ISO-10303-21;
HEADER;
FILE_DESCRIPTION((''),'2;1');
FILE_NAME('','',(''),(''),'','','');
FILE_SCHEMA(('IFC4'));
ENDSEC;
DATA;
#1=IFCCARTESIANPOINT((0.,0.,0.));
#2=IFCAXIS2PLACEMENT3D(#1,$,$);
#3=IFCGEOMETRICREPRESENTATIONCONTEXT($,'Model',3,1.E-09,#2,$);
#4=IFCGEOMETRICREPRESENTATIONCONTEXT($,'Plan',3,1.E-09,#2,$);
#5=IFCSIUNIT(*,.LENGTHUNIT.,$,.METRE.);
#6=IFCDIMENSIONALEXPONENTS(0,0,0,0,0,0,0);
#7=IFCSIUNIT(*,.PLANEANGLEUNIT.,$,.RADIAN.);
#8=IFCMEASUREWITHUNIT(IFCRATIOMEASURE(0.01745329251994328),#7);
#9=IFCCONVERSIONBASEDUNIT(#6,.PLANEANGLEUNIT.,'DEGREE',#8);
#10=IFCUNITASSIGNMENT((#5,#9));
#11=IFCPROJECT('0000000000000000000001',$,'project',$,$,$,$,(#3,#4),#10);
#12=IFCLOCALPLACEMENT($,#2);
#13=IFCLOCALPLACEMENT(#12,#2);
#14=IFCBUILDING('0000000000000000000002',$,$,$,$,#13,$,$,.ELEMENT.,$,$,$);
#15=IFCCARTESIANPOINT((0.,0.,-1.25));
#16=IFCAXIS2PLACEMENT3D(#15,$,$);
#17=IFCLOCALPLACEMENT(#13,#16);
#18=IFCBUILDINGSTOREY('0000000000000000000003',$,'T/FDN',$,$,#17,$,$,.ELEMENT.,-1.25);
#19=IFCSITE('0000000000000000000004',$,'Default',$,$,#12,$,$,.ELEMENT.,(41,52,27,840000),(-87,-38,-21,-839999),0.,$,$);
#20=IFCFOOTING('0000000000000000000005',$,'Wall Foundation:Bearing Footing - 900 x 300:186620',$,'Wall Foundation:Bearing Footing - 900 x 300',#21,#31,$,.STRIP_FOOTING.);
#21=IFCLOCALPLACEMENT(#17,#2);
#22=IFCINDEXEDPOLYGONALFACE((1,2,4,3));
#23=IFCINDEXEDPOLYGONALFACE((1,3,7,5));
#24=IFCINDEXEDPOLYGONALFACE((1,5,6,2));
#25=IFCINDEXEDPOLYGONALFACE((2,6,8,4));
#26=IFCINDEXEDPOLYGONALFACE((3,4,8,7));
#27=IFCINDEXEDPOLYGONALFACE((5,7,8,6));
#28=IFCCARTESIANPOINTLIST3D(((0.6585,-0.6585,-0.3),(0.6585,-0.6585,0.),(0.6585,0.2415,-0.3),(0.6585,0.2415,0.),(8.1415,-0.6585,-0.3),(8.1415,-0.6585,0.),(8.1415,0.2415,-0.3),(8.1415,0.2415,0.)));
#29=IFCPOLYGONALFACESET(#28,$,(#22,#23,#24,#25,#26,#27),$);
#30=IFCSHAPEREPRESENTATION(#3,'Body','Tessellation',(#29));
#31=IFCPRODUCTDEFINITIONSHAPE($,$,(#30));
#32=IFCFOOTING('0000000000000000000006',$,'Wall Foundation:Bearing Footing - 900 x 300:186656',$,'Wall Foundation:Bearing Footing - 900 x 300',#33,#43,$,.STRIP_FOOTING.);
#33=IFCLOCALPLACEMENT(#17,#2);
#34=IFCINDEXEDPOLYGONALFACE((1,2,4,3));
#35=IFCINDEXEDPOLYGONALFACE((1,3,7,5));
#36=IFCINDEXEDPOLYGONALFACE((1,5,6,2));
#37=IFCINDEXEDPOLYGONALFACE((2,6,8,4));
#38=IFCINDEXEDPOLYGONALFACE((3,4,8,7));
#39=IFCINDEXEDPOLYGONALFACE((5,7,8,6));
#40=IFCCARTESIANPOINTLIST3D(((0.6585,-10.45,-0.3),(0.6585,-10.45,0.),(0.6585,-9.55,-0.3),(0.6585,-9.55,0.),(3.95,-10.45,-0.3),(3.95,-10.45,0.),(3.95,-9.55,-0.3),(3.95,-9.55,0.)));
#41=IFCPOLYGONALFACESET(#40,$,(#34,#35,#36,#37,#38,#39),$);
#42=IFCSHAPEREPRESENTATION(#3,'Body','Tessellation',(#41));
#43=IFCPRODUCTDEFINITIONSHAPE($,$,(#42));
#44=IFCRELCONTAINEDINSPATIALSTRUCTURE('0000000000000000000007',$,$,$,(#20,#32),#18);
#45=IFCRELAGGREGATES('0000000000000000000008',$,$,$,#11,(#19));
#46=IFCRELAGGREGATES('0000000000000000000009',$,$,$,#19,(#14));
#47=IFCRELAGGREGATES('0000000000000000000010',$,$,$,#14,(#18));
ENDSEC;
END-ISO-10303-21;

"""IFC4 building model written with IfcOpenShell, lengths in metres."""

from ifc_helpers import new_model, entity, si_unit, converted_unit, frame, origin, origin_2d_with_axis, place, context, project, spatial, rectangle, extrude, element, save


model = new_model("IFC4")

# Units and contexts
model_context = context("Model", 3, precision=1e-09, world=origin())
plan_context = context("Plan", 3, precision=1e-09, world=origin())
ifc_project = project(units=[si_unit("LENGTHUNIT", "METRE"), converted_unit("PLANEANGLEUNIT", "DEGREE", entity("IfcRatioMeasure", 0.01745329251994328), si_unit("PLANEANGLEUNIT", "RADIAN"), dimensions=[0, 0, 0, 0, 0, 0, 0])], contexts=[model_context, plan_context])

# Site, building, storey
site_placement = place(None, origin())
site = spatial("IfcSite", under=ifc_project, at=site_placement, Name="Default", CompositionType="ELEMENT", RefLatitude=(41, 52, 27, 840000), RefLongitude=(-87, -38, -21, -839999), RefElevation=0.0)
building_placement = place(site_placement, origin())
building = spatial("IfcBuilding", under=site, at=building_placement, CompositionType="ELEMENT")
storey_placement = place(building_placement, frame((0.0, 0.0, -1.25)))
storey = spatial("IfcBuildingStorey", under=building, at=storey_placement, Name="T/FDN", CompositionType="ELEMENT", Elevation=-1.25)

# Footings
footing_1_placement = place(storey_placement, origin())
element("IfcFooting", 1, at=footing_1_placement, inside=storey, Name="Wall Foundation:Bearing Footing - 900 x 300:186620", ObjectType="Wall Foundation:Bearing Footing - 900 x 300", PredefinedType="STRIP_FOOTING", context=model_context, shape_type="SweptSolid", body=[
    extrude(rectangle(XDim=7.483, YDim=0.9, at=origin_2d_with_axis()), frame((4.4, -0.2085, -0.3), z_axis=(0.0, 0.0, 1.0), x_axis=(-1.0, 0.0, 0.0)), (0.0, 0.0, 1.0), 0.3),
])
footing_2_placement = place(storey_placement, origin())
element("IfcFooting", 2, at=footing_2_placement, inside=storey, Name="Wall Foundation:Bearing Footing - 900 x 300:186656", ObjectType="Wall Foundation:Bearing Footing - 900 x 300", PredefinedType="STRIP_FOOTING", context=model_context, shape_type="SweptSolid", body=[
    extrude(rectangle(XDim=3.2915, YDim=0.9, at=origin_2d_with_axis()), frame((2.3042, -10.0, -0.3)), (0.0, 0.0, 1.0), 0.3),
])

save(model, "model.ifc")
